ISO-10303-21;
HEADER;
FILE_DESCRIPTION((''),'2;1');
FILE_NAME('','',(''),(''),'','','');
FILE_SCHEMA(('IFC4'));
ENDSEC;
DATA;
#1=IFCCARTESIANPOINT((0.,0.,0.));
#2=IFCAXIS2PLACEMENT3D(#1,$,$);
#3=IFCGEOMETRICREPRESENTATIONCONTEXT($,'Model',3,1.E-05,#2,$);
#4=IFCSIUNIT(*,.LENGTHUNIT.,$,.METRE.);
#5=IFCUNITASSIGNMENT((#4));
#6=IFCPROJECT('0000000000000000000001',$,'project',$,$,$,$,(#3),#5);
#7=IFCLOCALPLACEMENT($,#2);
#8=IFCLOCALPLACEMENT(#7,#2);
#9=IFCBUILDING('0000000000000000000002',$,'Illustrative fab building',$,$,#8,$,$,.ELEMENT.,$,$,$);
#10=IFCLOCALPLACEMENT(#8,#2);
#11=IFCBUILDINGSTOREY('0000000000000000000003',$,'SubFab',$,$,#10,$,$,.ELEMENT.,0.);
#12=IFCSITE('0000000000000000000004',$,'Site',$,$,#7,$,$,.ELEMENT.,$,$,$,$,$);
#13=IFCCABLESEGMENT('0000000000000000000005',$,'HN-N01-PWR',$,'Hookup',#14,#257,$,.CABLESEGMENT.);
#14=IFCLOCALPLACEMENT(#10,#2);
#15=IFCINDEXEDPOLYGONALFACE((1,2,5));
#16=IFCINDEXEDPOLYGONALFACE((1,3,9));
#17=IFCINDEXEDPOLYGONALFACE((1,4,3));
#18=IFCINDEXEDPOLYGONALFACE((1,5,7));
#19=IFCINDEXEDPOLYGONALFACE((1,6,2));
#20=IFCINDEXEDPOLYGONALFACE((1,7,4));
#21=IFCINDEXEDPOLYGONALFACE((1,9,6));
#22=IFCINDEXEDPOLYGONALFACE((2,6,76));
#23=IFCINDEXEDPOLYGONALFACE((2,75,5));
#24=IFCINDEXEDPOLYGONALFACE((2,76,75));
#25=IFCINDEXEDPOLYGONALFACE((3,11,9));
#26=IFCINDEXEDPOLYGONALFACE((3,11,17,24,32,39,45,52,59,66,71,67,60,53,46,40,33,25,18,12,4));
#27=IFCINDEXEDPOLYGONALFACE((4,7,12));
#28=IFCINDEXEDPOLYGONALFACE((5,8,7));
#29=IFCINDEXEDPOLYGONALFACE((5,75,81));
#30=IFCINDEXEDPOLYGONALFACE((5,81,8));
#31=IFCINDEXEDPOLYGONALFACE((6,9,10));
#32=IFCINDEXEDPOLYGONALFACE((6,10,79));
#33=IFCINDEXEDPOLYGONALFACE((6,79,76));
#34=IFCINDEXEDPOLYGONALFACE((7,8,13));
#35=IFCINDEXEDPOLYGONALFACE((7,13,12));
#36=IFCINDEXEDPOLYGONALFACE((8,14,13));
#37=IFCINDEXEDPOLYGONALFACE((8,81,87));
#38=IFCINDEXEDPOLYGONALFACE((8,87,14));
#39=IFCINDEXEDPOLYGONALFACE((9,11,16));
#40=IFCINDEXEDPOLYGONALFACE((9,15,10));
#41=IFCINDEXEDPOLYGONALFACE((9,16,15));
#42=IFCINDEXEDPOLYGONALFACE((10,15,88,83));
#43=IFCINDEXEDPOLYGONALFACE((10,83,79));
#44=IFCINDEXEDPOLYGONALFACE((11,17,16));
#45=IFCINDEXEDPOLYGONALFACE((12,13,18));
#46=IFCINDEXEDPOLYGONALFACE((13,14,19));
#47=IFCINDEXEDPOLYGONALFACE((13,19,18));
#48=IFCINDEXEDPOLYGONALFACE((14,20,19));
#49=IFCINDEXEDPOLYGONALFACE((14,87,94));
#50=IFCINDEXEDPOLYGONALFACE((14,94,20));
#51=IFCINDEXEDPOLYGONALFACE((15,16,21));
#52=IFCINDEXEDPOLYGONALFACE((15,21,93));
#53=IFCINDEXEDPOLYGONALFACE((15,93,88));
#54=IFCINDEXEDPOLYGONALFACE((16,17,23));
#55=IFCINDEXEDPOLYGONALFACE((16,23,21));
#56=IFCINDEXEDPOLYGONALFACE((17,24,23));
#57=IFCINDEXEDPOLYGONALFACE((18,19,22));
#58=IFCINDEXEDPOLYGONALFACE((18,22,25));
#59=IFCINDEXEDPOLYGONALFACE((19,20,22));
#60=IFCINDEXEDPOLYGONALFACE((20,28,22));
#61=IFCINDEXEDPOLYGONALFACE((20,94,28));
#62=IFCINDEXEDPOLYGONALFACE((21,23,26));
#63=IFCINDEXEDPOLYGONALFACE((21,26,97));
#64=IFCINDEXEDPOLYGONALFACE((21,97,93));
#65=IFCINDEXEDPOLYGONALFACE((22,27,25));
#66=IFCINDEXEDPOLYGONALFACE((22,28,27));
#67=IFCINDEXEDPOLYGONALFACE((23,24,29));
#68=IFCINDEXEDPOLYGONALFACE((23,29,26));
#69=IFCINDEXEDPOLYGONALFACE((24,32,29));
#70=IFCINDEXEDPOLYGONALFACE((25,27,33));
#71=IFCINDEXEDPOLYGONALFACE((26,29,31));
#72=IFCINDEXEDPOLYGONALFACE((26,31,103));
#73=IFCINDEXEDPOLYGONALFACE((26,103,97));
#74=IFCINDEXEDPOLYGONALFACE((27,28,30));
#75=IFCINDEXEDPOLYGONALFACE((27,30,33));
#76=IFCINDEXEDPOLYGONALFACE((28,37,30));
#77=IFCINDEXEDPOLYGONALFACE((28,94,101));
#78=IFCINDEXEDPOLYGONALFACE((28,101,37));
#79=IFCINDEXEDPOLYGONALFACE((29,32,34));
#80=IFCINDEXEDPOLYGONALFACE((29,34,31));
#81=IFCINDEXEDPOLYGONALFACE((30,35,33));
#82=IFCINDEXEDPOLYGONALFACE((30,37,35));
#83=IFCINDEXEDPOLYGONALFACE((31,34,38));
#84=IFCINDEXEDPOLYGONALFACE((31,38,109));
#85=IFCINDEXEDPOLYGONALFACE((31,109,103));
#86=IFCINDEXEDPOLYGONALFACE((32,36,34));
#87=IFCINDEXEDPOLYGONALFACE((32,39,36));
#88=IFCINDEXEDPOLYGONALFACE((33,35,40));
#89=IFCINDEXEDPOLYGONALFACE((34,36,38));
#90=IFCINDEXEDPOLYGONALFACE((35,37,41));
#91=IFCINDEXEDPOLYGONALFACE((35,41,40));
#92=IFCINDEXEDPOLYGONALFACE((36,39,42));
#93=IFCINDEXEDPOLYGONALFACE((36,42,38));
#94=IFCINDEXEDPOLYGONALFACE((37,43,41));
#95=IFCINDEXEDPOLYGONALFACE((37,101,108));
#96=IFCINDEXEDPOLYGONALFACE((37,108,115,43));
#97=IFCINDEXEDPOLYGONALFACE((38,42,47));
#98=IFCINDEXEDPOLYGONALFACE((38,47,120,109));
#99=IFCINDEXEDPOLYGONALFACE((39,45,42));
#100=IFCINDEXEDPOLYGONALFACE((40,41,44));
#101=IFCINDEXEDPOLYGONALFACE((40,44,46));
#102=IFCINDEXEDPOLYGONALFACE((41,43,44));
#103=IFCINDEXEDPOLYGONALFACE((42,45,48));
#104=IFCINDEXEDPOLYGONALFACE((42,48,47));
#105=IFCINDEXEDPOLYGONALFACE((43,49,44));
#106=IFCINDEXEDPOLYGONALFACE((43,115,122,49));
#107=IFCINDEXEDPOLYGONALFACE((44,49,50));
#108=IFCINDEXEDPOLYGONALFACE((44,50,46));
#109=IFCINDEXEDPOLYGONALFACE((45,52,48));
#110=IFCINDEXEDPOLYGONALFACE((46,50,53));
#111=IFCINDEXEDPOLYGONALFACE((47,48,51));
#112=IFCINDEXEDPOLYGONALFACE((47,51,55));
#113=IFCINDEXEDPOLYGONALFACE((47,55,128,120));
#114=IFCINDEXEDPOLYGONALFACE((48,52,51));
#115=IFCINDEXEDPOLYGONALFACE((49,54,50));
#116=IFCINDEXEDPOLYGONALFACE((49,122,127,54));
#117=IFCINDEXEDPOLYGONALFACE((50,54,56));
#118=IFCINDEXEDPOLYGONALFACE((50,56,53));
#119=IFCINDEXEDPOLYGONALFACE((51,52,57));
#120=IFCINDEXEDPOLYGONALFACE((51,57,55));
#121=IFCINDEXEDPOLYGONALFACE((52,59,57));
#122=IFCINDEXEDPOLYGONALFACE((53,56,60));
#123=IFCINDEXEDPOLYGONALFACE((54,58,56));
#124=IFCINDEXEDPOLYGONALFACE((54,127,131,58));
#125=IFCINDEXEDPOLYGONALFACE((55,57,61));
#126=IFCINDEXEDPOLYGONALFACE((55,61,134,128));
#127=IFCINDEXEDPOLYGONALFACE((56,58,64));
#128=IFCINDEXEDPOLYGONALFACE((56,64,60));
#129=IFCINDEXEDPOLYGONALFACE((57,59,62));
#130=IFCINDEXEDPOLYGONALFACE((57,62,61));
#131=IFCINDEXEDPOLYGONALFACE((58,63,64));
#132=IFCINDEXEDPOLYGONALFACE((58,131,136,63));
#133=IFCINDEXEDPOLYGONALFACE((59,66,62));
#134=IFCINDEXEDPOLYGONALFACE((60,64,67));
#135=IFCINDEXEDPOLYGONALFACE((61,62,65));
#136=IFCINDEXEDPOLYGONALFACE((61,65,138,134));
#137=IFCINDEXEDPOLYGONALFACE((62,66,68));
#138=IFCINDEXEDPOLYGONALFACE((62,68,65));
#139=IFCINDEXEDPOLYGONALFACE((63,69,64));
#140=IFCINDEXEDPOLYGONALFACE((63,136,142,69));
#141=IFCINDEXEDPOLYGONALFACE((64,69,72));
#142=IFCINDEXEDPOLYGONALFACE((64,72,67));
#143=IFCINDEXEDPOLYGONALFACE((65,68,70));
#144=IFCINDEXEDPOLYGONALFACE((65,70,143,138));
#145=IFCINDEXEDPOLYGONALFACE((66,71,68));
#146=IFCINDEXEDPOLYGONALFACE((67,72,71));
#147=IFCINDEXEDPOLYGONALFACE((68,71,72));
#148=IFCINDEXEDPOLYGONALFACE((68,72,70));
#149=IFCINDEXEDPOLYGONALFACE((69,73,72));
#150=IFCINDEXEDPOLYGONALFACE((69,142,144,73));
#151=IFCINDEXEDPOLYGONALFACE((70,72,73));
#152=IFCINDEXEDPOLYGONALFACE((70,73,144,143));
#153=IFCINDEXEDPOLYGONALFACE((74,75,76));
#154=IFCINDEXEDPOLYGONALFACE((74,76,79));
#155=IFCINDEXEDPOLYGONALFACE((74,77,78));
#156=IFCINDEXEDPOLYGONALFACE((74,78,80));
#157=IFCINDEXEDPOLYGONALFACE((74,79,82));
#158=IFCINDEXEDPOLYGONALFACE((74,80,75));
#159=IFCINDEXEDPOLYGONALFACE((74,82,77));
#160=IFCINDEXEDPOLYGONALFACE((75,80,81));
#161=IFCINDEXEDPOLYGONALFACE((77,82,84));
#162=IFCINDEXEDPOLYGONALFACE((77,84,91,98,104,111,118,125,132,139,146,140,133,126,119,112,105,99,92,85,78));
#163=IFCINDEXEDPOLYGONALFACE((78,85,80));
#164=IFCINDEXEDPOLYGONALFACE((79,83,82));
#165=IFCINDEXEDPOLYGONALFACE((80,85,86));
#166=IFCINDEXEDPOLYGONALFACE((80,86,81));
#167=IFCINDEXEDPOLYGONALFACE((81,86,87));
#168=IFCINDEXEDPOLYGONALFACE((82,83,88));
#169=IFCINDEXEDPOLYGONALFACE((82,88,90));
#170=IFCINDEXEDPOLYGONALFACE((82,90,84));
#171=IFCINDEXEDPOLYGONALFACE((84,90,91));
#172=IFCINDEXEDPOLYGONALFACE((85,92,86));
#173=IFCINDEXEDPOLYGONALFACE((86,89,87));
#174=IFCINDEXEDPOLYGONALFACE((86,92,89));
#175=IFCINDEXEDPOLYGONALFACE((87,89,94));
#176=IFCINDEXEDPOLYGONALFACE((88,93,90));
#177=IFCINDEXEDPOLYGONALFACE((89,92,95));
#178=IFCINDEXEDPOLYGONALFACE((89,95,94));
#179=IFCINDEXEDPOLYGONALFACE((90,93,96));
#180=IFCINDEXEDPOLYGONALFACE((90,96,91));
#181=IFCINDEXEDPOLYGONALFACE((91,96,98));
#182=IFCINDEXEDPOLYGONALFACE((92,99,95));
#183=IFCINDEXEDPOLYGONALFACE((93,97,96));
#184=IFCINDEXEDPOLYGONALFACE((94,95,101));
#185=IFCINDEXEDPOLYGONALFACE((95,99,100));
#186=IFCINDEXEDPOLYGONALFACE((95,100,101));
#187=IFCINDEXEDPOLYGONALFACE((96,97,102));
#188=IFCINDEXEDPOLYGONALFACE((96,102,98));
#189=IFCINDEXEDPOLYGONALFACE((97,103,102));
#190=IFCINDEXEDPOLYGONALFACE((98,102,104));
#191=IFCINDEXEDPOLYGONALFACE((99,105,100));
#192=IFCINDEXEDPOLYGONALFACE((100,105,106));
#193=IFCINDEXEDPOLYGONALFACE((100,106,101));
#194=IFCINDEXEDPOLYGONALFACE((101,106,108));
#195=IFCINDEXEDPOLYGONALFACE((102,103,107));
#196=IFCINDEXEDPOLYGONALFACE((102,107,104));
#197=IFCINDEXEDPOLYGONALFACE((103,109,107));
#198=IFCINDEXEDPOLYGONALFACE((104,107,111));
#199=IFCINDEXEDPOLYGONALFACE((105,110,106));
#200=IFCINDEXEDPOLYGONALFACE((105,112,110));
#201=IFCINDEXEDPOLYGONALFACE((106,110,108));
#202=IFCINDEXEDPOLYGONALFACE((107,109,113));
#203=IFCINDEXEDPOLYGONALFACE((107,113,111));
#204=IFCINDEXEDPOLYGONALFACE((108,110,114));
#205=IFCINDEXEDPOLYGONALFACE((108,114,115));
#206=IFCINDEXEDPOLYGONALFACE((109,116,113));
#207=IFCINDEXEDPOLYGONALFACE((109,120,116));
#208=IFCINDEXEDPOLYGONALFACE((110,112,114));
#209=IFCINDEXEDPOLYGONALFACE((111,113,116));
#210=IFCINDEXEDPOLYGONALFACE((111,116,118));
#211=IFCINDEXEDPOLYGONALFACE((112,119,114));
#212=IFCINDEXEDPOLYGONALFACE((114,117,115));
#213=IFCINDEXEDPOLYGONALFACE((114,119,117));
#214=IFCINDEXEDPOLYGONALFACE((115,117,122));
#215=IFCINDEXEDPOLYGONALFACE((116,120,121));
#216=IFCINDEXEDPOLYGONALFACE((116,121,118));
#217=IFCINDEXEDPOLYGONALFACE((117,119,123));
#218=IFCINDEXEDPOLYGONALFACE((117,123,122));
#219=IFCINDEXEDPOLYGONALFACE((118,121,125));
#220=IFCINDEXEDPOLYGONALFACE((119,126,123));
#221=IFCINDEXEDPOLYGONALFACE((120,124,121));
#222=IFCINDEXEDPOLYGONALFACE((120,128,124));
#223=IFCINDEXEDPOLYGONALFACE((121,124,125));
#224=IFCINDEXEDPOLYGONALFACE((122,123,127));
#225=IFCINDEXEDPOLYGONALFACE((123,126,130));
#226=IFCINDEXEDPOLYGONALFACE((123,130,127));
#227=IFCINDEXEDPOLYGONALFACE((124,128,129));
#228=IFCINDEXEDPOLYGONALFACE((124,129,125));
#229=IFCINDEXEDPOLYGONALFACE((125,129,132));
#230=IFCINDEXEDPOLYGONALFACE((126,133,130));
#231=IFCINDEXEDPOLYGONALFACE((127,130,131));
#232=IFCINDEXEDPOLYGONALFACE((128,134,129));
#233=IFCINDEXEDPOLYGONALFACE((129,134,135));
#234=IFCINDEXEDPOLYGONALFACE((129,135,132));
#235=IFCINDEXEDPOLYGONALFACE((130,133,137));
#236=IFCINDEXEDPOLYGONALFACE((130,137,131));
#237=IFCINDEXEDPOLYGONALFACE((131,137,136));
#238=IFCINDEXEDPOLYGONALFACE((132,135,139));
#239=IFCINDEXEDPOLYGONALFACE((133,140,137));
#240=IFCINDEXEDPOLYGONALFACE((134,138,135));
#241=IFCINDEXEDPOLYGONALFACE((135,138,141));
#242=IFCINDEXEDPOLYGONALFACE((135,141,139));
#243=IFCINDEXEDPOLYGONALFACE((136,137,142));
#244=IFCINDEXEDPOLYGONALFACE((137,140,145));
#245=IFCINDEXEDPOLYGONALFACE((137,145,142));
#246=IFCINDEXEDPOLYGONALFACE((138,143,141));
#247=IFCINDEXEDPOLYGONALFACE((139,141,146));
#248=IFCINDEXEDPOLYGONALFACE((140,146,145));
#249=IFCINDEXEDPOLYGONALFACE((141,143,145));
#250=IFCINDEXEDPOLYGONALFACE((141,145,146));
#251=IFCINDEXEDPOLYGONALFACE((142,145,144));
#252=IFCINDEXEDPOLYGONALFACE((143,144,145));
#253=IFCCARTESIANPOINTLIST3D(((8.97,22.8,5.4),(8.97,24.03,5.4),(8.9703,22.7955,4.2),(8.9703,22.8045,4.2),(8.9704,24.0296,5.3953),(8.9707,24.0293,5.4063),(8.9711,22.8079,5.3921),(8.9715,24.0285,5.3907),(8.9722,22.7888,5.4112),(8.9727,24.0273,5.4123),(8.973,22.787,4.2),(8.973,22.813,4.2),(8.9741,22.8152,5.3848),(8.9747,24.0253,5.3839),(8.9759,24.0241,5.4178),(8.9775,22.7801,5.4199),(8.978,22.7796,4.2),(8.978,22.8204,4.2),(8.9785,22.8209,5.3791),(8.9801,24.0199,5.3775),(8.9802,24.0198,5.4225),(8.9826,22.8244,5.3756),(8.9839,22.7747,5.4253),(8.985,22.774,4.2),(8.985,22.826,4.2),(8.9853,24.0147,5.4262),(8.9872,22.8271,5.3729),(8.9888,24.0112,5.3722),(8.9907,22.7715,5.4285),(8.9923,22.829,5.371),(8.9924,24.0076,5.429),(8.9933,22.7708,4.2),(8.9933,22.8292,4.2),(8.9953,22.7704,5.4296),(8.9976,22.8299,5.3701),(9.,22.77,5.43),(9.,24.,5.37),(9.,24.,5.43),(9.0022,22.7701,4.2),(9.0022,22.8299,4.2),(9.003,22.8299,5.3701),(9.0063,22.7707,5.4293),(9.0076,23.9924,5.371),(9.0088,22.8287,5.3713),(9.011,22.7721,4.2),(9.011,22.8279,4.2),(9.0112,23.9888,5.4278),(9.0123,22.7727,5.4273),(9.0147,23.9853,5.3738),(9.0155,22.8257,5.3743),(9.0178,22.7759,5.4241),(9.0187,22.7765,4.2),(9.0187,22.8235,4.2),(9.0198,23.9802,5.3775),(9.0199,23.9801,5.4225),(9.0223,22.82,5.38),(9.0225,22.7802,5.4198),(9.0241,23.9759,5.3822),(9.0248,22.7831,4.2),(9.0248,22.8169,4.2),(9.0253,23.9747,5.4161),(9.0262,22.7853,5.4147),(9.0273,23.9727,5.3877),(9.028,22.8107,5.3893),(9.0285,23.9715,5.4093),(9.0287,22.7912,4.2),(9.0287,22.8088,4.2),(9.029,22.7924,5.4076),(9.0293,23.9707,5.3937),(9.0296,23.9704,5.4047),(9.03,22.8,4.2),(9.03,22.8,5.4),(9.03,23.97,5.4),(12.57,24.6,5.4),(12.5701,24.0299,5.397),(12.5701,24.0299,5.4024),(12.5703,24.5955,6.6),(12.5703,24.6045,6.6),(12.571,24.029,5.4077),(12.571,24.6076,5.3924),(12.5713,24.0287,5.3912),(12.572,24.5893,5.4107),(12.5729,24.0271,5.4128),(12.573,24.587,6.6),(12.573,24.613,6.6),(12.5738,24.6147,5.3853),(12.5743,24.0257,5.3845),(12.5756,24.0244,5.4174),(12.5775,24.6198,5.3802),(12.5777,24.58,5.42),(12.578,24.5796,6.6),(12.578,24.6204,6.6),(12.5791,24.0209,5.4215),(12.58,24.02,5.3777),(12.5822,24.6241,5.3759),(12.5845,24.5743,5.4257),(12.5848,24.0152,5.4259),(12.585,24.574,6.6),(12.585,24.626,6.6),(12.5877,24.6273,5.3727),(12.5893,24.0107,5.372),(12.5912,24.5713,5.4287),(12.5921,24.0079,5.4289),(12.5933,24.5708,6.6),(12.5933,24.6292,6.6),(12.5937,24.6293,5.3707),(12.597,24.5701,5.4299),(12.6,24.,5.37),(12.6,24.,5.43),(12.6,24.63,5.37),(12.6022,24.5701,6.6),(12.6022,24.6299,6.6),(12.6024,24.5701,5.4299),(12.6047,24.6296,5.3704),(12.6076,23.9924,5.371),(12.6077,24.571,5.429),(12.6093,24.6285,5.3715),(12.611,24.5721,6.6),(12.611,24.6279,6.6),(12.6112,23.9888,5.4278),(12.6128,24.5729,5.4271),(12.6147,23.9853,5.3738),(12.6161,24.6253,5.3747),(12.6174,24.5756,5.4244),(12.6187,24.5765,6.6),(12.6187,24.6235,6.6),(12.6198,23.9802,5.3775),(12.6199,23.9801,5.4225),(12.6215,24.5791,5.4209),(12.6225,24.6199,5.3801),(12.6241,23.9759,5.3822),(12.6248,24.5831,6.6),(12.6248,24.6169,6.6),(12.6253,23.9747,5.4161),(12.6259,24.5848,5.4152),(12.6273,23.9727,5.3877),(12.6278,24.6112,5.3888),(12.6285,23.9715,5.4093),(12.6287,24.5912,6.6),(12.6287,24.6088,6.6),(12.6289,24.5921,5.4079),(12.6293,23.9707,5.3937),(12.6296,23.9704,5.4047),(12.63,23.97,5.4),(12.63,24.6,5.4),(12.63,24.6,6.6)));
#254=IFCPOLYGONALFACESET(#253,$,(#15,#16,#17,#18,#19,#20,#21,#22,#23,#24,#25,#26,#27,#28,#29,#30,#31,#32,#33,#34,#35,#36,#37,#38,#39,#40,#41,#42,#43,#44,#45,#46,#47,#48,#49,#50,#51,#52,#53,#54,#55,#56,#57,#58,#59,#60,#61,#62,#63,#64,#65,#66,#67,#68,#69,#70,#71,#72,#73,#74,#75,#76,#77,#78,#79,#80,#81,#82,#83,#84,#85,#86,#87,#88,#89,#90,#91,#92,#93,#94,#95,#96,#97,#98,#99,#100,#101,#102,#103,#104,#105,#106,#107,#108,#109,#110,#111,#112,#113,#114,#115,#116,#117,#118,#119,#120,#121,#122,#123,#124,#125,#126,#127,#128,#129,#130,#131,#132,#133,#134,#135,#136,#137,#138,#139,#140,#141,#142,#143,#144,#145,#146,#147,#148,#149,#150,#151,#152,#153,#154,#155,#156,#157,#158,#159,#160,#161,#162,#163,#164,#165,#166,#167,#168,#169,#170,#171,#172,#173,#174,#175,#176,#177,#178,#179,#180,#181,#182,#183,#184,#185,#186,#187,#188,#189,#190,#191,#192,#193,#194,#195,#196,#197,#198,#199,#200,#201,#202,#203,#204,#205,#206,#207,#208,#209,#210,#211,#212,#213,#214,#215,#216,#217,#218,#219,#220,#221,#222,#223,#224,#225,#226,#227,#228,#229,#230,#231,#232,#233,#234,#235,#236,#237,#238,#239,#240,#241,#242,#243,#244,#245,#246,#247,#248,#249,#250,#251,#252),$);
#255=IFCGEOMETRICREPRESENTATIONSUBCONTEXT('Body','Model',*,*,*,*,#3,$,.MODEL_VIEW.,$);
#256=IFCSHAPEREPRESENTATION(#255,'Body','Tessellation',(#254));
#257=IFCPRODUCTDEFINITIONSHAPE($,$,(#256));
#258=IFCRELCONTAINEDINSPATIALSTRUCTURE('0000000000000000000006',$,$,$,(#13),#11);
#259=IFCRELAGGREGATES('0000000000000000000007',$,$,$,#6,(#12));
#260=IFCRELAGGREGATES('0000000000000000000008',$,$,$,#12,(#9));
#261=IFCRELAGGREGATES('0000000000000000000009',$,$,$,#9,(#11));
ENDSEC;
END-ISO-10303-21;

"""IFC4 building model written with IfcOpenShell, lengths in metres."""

from ifc_helpers import new_model, entity, si_unit, origin, place, context, subcontext, project, spatial, element, save


model = new_model("IFC4")

# Units and contexts
model_context = context("Model", 3, precision=1e-05, world=origin())
body_context = subcontext(model_context, "Body", "Model", "MODEL_VIEW")
ifc_project = project(units=[si_unit("LENGTHUNIT", "METRE")], contexts=[model_context])

# Site, building, storey
site_placement = place(None, origin())
site = spatial("IfcSite", under=ifc_project, at=site_placement, Name="Site", CompositionType="ELEMENT")
building_placement = place(site_placement, origin())
building = spatial("IfcBuilding", under=site, at=building_placement, Name="Illustrative fab building", CompositionType="ELEMENT")
storey_placement = place(building_placement, origin())
storey = spatial("IfcBuildingStorey", under=building, at=storey_placement, Name="SubFab", CompositionType="ELEMENT", Elevation=0.0)

# Cable segment
cable_segment_1_placement = place(storey_placement, origin())
element("IfcCableSegment", 1, at=cable_segment_1_placement, inside=storey, Name="HN-N01-PWR", ObjectType="Hookup", PredefinedType="CABLESEGMENT", context=body_context, shape_type="AdvancedSweptSolid", body=[
    entity("IfcSweptDiskSolid", entity("IfcPolyline", [entity("IfcCartesianPoint", [9.0, 22.8, 4.2]), entity("IfcCartesianPoint", [9.0, 22.8, 5.4]), entity("IfcCartesianPoint", [9.0, 24.0, 5.4]), entity("IfcCartesianPoint", [12.6, 24.0, 5.4]), entity("IfcCartesianPoint", [12.6, 24.6, 5.4]), entity("IfcCartesianPoint", [12.6, 24.6, 6.6])]), 0.03),
])

save(model, "model.ifc")
